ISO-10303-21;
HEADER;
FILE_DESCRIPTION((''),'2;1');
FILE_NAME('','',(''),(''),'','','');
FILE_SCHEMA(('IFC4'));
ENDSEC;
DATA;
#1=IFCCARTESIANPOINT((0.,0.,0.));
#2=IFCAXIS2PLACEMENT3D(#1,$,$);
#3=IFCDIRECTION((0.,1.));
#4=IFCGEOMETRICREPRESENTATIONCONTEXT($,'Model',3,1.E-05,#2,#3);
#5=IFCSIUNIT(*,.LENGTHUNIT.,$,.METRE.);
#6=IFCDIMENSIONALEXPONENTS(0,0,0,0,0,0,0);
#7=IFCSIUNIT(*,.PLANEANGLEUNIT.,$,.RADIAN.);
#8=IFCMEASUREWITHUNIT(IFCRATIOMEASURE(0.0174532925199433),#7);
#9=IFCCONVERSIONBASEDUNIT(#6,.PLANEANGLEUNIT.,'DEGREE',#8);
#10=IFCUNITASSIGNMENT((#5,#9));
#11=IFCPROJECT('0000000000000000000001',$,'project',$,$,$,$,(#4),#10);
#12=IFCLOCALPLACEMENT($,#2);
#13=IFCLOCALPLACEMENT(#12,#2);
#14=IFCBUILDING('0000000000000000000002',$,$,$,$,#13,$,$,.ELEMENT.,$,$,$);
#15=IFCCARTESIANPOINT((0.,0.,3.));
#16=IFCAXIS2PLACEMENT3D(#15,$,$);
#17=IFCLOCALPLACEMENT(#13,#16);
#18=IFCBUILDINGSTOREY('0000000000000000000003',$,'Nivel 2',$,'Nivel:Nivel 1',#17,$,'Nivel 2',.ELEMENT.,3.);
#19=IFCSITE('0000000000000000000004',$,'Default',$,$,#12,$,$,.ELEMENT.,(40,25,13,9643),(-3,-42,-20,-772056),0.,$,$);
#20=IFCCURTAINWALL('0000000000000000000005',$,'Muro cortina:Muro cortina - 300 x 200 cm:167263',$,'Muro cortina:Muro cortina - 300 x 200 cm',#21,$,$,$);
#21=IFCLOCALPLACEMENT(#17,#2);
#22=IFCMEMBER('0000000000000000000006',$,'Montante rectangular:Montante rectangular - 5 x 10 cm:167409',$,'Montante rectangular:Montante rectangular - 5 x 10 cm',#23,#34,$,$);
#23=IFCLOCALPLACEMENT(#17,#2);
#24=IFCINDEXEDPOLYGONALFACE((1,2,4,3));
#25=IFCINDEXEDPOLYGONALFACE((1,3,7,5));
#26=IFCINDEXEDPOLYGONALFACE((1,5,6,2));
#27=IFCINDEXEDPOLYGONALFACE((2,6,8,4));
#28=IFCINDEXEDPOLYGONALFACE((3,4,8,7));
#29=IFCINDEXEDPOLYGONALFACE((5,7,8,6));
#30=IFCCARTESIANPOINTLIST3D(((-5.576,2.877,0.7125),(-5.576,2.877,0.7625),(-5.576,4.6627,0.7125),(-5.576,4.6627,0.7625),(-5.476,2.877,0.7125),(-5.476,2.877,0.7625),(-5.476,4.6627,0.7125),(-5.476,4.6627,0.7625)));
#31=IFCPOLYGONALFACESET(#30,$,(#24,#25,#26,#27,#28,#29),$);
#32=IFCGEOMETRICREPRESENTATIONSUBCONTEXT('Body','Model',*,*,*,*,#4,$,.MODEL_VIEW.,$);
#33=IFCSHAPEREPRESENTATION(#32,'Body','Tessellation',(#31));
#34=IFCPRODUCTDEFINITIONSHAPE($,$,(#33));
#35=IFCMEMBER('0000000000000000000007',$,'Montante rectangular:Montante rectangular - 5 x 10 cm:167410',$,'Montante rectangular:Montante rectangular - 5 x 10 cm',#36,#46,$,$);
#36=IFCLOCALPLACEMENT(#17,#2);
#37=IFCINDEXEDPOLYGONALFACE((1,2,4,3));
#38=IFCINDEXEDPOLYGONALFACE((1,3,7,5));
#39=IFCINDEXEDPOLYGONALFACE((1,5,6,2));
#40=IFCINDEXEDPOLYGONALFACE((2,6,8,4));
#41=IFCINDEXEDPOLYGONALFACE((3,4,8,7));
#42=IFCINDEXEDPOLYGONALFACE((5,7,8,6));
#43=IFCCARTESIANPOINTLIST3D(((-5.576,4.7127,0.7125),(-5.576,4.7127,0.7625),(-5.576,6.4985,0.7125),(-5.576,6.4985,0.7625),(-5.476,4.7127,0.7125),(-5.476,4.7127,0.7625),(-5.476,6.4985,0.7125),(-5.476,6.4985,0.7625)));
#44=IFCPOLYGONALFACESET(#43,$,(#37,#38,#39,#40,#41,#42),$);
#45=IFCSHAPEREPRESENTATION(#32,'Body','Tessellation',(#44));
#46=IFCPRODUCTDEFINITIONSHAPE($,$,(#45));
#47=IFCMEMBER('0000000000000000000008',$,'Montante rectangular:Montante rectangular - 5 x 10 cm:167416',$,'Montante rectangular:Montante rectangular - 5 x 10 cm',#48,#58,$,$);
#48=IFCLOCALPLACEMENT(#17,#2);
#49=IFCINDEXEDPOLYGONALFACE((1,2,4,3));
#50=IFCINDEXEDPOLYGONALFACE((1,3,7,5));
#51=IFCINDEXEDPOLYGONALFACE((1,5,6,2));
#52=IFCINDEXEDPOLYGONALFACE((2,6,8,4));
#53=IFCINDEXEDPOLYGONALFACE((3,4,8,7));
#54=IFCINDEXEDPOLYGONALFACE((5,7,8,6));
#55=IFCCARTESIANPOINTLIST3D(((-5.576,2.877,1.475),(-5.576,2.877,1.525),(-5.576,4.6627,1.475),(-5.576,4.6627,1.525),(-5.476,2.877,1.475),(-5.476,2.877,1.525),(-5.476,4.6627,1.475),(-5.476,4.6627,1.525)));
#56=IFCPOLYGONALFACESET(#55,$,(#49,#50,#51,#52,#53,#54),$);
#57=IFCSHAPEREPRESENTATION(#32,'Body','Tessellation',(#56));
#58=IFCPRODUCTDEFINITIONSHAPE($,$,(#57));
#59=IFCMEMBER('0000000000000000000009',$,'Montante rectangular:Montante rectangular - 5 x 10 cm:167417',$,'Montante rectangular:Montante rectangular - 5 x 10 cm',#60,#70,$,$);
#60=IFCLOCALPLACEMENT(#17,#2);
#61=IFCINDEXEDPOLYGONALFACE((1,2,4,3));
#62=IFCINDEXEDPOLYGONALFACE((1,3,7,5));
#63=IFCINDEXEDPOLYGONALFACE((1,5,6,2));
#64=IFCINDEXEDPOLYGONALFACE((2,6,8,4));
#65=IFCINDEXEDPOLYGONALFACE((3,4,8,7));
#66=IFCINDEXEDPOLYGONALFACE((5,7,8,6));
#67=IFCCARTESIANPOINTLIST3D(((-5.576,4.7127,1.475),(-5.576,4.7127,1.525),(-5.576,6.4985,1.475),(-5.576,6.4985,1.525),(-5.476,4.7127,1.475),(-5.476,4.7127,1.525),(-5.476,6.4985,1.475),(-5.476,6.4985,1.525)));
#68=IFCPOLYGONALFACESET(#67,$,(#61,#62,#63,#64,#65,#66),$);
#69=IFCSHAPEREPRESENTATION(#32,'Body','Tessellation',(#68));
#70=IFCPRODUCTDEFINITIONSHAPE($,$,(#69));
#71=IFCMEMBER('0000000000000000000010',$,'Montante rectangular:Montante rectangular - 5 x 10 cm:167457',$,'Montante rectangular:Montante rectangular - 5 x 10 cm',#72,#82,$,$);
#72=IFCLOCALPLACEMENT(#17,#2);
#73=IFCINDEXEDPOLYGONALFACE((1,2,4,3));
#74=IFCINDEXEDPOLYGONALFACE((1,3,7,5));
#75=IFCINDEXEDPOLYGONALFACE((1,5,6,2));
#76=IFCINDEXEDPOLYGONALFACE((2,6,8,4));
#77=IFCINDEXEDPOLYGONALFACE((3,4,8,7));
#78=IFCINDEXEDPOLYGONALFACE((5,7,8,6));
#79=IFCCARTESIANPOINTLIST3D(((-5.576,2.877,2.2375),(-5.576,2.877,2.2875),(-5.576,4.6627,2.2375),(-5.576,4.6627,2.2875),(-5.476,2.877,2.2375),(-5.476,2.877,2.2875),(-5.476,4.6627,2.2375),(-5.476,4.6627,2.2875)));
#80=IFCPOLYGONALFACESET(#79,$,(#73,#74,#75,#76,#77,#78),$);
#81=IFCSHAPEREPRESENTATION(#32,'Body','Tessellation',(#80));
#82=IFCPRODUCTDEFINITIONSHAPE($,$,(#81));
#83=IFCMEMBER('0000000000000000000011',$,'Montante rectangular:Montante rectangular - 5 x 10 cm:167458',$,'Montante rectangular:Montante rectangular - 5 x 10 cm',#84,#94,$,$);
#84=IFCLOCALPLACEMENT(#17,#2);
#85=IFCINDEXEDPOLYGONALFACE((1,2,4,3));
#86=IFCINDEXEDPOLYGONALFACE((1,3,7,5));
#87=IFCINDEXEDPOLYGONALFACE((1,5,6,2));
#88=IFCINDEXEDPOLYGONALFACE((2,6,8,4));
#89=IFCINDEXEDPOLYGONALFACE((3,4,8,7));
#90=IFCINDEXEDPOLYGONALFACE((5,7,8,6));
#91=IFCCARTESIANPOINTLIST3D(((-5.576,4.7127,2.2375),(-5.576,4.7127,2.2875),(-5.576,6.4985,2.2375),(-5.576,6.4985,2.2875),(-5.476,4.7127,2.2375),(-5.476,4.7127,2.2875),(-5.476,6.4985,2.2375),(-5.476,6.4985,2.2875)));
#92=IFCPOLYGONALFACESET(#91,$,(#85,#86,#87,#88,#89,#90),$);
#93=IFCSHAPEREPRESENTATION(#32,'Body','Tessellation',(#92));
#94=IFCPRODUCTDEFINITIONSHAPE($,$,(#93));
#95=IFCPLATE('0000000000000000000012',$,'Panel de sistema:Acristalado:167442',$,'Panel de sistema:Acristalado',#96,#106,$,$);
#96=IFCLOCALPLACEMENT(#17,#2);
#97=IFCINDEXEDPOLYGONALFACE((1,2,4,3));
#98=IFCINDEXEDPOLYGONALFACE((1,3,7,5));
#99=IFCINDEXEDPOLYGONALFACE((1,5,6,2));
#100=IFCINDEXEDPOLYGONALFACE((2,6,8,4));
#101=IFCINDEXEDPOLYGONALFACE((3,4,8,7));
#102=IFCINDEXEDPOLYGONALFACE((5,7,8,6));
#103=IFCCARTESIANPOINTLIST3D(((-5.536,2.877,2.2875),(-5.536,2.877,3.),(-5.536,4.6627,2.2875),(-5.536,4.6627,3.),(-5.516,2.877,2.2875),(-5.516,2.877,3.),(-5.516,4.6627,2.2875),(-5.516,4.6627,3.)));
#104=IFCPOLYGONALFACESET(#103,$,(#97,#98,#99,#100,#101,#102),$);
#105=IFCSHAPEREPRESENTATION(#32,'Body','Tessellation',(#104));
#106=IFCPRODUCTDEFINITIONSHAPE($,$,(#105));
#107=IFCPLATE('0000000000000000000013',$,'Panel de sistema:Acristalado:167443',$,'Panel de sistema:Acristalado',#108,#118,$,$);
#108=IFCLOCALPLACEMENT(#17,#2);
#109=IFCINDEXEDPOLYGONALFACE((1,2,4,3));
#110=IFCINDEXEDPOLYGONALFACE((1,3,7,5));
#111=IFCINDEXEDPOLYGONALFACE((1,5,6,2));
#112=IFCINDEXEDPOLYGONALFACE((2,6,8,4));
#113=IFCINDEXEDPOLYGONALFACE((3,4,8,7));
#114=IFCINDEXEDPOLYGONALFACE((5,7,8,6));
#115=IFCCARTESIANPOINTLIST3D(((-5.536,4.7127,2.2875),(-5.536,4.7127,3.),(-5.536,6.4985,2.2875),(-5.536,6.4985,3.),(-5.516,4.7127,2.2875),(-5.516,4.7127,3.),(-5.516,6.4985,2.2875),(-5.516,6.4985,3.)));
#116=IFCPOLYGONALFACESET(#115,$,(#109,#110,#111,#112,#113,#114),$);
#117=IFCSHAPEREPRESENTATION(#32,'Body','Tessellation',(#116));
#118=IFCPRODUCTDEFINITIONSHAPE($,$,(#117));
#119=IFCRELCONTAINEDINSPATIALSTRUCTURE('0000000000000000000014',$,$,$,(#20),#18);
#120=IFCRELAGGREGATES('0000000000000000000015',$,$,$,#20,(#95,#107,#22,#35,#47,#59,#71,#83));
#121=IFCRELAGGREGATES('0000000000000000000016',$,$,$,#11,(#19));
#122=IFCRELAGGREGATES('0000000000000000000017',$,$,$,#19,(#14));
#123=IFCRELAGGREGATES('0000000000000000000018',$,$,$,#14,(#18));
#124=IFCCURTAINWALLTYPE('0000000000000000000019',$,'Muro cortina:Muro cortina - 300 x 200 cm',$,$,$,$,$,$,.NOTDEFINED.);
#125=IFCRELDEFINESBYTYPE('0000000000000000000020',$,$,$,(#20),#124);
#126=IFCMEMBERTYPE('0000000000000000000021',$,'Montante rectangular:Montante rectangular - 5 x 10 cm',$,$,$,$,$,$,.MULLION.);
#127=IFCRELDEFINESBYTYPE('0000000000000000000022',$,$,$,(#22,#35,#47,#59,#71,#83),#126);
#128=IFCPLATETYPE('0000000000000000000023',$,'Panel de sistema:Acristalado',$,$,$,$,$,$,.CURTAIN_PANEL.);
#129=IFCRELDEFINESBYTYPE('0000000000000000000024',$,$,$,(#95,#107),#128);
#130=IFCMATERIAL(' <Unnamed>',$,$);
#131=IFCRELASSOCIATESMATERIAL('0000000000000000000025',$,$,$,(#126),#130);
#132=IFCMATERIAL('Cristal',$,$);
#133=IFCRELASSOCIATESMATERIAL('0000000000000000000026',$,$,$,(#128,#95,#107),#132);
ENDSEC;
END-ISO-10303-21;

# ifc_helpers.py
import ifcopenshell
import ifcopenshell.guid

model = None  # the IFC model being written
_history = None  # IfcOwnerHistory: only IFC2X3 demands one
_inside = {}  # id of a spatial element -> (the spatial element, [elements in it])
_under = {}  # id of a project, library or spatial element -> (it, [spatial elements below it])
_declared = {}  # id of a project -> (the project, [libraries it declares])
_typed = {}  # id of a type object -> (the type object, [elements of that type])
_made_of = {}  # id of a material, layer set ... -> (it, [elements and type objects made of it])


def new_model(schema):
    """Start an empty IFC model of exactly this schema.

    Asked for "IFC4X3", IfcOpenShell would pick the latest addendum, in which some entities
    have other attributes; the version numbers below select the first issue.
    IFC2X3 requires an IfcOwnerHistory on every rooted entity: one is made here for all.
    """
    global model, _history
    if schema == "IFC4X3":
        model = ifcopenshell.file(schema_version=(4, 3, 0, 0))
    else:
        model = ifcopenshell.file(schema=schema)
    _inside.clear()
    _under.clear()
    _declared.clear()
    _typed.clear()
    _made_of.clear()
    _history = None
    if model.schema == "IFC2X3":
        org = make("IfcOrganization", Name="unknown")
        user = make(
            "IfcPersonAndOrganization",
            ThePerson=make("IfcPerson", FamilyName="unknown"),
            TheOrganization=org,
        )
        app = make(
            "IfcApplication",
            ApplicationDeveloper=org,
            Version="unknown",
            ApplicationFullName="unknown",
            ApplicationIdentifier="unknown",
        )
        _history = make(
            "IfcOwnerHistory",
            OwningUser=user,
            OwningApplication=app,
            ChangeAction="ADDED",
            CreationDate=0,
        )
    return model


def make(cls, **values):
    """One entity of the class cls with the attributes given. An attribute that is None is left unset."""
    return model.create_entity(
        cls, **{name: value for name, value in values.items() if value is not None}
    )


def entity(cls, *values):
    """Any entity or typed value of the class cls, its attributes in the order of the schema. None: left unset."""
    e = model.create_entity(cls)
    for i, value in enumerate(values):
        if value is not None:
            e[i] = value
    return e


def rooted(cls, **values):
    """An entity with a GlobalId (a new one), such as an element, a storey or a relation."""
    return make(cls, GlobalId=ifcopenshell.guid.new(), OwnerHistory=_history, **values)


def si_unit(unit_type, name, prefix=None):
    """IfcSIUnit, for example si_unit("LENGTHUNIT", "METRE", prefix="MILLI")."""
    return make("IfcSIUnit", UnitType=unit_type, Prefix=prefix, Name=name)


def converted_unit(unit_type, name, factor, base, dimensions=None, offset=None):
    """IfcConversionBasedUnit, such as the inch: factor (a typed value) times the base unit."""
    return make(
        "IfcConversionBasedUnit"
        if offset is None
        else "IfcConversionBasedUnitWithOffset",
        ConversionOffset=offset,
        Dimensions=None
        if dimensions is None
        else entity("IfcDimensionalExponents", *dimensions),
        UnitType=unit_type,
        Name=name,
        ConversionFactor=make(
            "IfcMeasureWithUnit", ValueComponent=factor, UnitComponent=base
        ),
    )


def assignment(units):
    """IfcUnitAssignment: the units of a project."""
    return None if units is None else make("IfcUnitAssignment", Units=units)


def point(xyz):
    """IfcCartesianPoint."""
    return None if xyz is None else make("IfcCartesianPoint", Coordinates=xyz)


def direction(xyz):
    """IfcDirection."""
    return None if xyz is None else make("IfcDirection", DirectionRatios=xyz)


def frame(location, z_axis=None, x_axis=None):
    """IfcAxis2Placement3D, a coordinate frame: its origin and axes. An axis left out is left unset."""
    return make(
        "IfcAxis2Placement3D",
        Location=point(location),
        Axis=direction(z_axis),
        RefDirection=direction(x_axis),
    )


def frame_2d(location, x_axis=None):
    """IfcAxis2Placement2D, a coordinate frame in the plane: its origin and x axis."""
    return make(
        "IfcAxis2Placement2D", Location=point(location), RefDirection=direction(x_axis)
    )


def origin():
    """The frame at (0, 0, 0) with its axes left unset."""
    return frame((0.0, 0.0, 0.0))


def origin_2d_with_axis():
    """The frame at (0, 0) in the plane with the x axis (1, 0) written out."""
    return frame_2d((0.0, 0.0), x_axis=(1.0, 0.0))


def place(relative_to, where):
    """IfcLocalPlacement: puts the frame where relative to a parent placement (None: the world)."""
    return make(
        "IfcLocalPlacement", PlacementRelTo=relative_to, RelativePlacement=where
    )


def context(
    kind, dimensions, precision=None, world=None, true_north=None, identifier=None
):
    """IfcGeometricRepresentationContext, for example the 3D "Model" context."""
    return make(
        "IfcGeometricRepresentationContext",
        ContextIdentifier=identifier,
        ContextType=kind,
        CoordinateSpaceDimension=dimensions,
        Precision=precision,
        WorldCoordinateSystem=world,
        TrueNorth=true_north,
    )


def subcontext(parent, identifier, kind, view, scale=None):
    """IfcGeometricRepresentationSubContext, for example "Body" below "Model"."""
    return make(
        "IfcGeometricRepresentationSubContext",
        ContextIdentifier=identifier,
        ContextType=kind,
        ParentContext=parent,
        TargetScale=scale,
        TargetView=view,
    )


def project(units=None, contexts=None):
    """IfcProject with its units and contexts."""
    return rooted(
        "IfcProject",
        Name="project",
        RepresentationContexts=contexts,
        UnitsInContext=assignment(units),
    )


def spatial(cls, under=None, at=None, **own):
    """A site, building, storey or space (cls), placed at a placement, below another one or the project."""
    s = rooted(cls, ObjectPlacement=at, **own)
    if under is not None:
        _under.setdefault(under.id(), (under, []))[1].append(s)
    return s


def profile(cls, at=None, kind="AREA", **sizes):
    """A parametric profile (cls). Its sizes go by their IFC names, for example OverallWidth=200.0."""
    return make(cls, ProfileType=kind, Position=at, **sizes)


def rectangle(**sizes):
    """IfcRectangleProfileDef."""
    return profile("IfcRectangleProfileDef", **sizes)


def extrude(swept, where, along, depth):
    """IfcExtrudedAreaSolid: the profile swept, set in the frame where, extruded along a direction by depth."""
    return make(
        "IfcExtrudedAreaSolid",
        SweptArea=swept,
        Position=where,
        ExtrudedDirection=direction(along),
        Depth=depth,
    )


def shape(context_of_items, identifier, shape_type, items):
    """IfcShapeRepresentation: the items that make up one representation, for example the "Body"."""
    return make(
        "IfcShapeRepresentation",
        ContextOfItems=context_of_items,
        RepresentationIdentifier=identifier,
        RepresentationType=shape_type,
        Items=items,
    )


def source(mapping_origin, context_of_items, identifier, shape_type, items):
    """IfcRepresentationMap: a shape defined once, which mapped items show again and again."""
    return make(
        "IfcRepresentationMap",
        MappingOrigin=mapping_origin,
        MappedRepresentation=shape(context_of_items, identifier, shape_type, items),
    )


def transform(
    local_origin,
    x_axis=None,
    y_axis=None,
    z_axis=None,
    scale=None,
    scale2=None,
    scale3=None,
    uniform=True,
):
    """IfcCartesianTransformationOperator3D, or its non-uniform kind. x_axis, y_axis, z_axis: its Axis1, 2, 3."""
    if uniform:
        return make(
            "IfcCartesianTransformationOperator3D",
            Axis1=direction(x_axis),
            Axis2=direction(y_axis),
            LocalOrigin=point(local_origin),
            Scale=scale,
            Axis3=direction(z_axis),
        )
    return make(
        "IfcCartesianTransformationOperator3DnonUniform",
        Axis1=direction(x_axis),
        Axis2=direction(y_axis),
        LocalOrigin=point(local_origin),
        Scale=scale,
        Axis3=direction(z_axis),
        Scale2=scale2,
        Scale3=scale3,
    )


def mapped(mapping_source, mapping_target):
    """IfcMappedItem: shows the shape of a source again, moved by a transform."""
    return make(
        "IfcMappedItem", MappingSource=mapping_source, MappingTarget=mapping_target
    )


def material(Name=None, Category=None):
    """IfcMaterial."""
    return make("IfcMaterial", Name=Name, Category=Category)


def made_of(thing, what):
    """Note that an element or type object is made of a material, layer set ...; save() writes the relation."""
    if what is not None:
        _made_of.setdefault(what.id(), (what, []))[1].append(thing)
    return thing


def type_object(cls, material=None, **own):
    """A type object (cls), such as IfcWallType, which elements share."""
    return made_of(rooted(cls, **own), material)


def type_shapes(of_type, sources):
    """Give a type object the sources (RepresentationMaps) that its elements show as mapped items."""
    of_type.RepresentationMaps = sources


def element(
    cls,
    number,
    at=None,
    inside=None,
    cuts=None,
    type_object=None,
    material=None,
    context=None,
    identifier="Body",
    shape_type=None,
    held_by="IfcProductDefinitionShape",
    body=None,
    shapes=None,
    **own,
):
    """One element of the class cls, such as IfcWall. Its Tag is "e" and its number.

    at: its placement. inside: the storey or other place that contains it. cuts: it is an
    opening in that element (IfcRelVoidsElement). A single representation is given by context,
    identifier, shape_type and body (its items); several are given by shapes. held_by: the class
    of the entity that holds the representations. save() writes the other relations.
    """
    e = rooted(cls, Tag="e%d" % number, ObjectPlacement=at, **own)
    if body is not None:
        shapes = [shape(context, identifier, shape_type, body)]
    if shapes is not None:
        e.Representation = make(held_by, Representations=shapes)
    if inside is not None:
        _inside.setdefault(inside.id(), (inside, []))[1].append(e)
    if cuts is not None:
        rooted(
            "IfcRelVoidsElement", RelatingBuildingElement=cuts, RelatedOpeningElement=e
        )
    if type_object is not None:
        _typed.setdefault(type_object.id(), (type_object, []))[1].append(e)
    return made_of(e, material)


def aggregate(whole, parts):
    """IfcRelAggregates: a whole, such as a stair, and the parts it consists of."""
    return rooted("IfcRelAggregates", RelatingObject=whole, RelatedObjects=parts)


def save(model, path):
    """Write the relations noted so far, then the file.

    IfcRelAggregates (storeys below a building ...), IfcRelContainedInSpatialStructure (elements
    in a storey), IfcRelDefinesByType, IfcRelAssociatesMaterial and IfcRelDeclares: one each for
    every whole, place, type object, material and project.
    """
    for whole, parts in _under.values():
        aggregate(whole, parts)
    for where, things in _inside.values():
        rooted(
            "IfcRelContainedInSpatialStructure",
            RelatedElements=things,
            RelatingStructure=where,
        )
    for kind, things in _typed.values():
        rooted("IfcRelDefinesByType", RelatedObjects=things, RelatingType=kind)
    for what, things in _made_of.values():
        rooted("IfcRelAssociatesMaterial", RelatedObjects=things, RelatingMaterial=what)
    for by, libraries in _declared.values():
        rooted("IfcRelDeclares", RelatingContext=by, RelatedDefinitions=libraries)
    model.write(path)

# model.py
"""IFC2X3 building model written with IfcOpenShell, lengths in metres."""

from ifc_helpers import new_model, entity, si_unit, converted_unit, direction, frame, origin, origin_2d_with_axis, place, context, subcontext, project, spatial, rectangle, extrude, source, transform, mapped, material, type_object, type_shapes, element, aggregate, save


model = new_model("IFC2X3")

# Units and contexts
model_context = context("Model", 3, precision=1e-05, world=origin(), true_north=direction((0.0, 1.0)))
body_context = subcontext(model_context, "Body", "Model", "MODEL_VIEW")
ifc_project = project(units=[si_unit("LENGTHUNIT", "METRE"), converted_unit("PLANEANGLEUNIT", "DEGREE", entity("IfcRatioMeasure", 0.0174532925199433), si_unit("PLANEANGLEUNIT", "RADIAN"), dimensions=[0, 0, 0, 0, 0, 0, 0])], contexts=[model_context])

# Site, building, storey
site_placement = place(None, origin())
site = spatial("IfcSite", under=ifc_project, at=site_placement, Name="Default", CompositionType="ELEMENT", RefLatitude=(40, 25, 13, 9643), RefLongitude=(-3, -42, -20, -772056), RefElevation=0.0)
building_placement = place(site_placement, origin())
building = spatial("IfcBuilding", under=site, at=building_placement, CompositionType="ELEMENT")
storey_placement = place(building_placement, frame((0.0, 0.0, 3.0)))
storey = spatial("IfcBuildingStorey", under=building, at=storey_placement, Name="Nivel 2", ObjectType="Nivel:Nivel 1", LongName="Nivel 2", CompositionType="ELEMENT", Elevation=3.0)

# Curtain wall
curtain_wall_type = type_object("IfcCurtainWallType", Name="Muro cortina:Muro cortina - 300 x 200 cm", PredefinedType="NOTDEFINED")
curtain_wall_1_placement = place(storey_placement, frame((0.0, 0.0, -3.0)))
curtain_wall_1 = element("IfcCurtainWall", 1, at=curtain_wall_1_placement, inside=storey, type_object=curtain_wall_type, Name="Muro cortina:Muro cortina - 300 x 200 cm:167263", ObjectType="Muro cortina:Muro cortina - 300 x 200 cm")
ifc_material_1 = material(Name=" <Unnamed>")

# Members
member_type_1 = type_object("IfcMemberType", Name="Montante rectangular:Montante rectangular - 5 x 10 cm", PredefinedType="MULLION", material=ifc_material_1)
shared_shape_1 = source(origin(), body_context, "Body", "SweptSolid", [
    extrude(rectangle(XDim=0.1, YDim=0.05, at=origin_2d_with_axis()), frame((0.0, 0.0, -1.7857), z_axis=(0.0, 0.0, 1.0), x_axis=(0.0, -1.0, 0.0)), (0.0, 0.0, 1.0), 1.7857),
])
type_shapes(member_type_1, [shared_shape_1])
member_1_placement = place(storey_placement, frame((-5.526, 4.6627, 0.7375), z_axis=(0.0, 1.0, 0.0), x_axis=(0.0, 0.0, 1.0)))
member_1 = element("IfcMember", 2, at=member_1_placement, type_object=member_type_1, Name="Montante rectangular:Montante rectangular - 5 x 10 cm:167409", ObjectType="Montante rectangular:Montante rectangular - 5 x 10 cm", context=body_context, shape_type="MappedRepresentation", body=[
    mapped(shared_shape_1, transform((0.0, 0.0, 0.0), scale=1.0)),
])
member_2_placement = place(storey_placement, frame((-5.526, 6.4985, 0.7375), z_axis=(0.0, 1.0, 0.0), x_axis=(0.0, 0.0, 1.0)))
member_2 = element("IfcMember", 3, at=member_2_placement, type_object=member_type_1, Name="Montante rectangular:Montante rectangular - 5 x 10 cm:167410", ObjectType="Montante rectangular:Montante rectangular - 5 x 10 cm", context=body_context, shape_type="MappedRepresentation", body=[
    mapped(shared_shape_1, transform((0.0, 0.0, 0.0), scale=1.0)),
])
member_3_placement = place(storey_placement, frame((-5.526, 4.6627, 1.5), z_axis=(0.0, 1.0, 0.0), x_axis=(0.0, 0.0, 1.0)))
member_3 = element("IfcMember", 4, at=member_3_placement, type_object=member_type_1, Name="Montante rectangular:Montante rectangular - 5 x 10 cm:167416", ObjectType="Montante rectangular:Montante rectangular - 5 x 10 cm", context=body_context, shape_type="MappedRepresentation", body=[
    mapped(shared_shape_1, transform((0.0, 0.0, 0.0), scale=1.0)),
])
member_4_placement = place(storey_placement, frame((-5.526, 6.4985, 1.5), z_axis=(0.0, 1.0, 0.0), x_axis=(0.0, 0.0, 1.0)))
member_4 = element("IfcMember", 5, at=member_4_placement, type_object=member_type_1, Name="Montante rectangular:Montante rectangular - 5 x 10 cm:167417", ObjectType="Montante rectangular:Montante rectangular - 5 x 10 cm", context=body_context, shape_type="MappedRepresentation", body=[
    mapped(shared_shape_1, transform((0.0, 0.0, 0.0), scale=1.0)),
])
member_5_placement = place(storey_placement, frame((-5.526, 4.6627, 2.2625), z_axis=(0.0, 1.0, 0.0), x_axis=(0.0, 0.0, 1.0)))
member_5 = element("IfcMember", 6, at=member_5_placement, type_object=member_type_1, Name="Montante rectangular:Montante rectangular - 5 x 10 cm:167457", ObjectType="Montante rectangular:Montante rectangular - 5 x 10 cm", context=body_context, shape_type="MappedRepresentation", body=[
    mapped(shared_shape_1, transform((0.0, 0.0, 0.0), scale=1.0)),
])
member_6_placement = place(storey_placement, frame((-5.526, 6.4985, 2.2625), z_axis=(0.0, 1.0, 0.0), x_axis=(0.0, 0.0, 1.0)))
member_6 = element("IfcMember", 7, at=member_6_placement, type_object=member_type_1, Name="Montante rectangular:Montante rectangular - 5 x 10 cm:167458", ObjectType="Montante rectangular:Montante rectangular - 5 x 10 cm", context=body_context, shape_type="MappedRepresentation", body=[
    mapped(shared_shape_1, transform((0.0, 0.0, 0.0), scale=1.0)),
])

# Plates
ifc_material_2 = material(Name="Cristal")
plate_type_1 = type_object("IfcPlateType", Name="Panel de sistema:Acristalado", PredefinedType="CURTAIN_PANEL", material=ifc_material_2)
shared_shape_2 = source(origin(), body_context, "Body", "SweptSolid", [
    extrude(rectangle(XDim=0.02, YDim=1.7857, at=origin_2d_with_axis()), frame((0.0, 0.0, 0.0), z_axis=(0.0, 0.0, 1.0), x_axis=(0.0, 1.0, 0.0)), (0.0, 0.0, 1.0), 0.7125),
])
type_shapes(plate_type_1, [shared_shape_2])
plate_1_placement = place(curtain_wall_1_placement, frame((-5.526, 3.7699, 5.2875), z_axis=(0.0, 0.0, 1.0), x_axis=(0.0, 1.0, 0.0)))
plate_1 = element("IfcPlate", 8, at=plate_1_placement, type_object=plate_type_1, material=ifc_material_2, Name="Panel de sistema:Acristalado:167442", ObjectType="Panel de sistema:Acristalado", context=body_context, shape_type="MappedRepresentation", body=[
    mapped(shared_shape_2, transform((0.0, 0.0, 0.0), scale=1.0)),
])
plate_2_placement = place(curtain_wall_1_placement, frame((-5.526, 5.6056, 5.2875), z_axis=(0.0, 0.0, 1.0), x_axis=(0.0, 1.0, 0.0)))
plate_2 = element("IfcPlate", 9, at=plate_2_placement, type_object=plate_type_1, material=ifc_material_2, Name="Panel de sistema:Acristalado:167443", ObjectType="Panel de sistema:Acristalado", context=body_context, shape_type="MappedRepresentation", body=[
    mapped(shared_shape_2, transform((0.0, 0.0, 0.0), scale=1.0)),
])
aggregate(curtain_wall_1, [plate_1, plate_2, member_1, member_2, member_3, member_4, member_5, member_6])

save(model, "model.ifc")
